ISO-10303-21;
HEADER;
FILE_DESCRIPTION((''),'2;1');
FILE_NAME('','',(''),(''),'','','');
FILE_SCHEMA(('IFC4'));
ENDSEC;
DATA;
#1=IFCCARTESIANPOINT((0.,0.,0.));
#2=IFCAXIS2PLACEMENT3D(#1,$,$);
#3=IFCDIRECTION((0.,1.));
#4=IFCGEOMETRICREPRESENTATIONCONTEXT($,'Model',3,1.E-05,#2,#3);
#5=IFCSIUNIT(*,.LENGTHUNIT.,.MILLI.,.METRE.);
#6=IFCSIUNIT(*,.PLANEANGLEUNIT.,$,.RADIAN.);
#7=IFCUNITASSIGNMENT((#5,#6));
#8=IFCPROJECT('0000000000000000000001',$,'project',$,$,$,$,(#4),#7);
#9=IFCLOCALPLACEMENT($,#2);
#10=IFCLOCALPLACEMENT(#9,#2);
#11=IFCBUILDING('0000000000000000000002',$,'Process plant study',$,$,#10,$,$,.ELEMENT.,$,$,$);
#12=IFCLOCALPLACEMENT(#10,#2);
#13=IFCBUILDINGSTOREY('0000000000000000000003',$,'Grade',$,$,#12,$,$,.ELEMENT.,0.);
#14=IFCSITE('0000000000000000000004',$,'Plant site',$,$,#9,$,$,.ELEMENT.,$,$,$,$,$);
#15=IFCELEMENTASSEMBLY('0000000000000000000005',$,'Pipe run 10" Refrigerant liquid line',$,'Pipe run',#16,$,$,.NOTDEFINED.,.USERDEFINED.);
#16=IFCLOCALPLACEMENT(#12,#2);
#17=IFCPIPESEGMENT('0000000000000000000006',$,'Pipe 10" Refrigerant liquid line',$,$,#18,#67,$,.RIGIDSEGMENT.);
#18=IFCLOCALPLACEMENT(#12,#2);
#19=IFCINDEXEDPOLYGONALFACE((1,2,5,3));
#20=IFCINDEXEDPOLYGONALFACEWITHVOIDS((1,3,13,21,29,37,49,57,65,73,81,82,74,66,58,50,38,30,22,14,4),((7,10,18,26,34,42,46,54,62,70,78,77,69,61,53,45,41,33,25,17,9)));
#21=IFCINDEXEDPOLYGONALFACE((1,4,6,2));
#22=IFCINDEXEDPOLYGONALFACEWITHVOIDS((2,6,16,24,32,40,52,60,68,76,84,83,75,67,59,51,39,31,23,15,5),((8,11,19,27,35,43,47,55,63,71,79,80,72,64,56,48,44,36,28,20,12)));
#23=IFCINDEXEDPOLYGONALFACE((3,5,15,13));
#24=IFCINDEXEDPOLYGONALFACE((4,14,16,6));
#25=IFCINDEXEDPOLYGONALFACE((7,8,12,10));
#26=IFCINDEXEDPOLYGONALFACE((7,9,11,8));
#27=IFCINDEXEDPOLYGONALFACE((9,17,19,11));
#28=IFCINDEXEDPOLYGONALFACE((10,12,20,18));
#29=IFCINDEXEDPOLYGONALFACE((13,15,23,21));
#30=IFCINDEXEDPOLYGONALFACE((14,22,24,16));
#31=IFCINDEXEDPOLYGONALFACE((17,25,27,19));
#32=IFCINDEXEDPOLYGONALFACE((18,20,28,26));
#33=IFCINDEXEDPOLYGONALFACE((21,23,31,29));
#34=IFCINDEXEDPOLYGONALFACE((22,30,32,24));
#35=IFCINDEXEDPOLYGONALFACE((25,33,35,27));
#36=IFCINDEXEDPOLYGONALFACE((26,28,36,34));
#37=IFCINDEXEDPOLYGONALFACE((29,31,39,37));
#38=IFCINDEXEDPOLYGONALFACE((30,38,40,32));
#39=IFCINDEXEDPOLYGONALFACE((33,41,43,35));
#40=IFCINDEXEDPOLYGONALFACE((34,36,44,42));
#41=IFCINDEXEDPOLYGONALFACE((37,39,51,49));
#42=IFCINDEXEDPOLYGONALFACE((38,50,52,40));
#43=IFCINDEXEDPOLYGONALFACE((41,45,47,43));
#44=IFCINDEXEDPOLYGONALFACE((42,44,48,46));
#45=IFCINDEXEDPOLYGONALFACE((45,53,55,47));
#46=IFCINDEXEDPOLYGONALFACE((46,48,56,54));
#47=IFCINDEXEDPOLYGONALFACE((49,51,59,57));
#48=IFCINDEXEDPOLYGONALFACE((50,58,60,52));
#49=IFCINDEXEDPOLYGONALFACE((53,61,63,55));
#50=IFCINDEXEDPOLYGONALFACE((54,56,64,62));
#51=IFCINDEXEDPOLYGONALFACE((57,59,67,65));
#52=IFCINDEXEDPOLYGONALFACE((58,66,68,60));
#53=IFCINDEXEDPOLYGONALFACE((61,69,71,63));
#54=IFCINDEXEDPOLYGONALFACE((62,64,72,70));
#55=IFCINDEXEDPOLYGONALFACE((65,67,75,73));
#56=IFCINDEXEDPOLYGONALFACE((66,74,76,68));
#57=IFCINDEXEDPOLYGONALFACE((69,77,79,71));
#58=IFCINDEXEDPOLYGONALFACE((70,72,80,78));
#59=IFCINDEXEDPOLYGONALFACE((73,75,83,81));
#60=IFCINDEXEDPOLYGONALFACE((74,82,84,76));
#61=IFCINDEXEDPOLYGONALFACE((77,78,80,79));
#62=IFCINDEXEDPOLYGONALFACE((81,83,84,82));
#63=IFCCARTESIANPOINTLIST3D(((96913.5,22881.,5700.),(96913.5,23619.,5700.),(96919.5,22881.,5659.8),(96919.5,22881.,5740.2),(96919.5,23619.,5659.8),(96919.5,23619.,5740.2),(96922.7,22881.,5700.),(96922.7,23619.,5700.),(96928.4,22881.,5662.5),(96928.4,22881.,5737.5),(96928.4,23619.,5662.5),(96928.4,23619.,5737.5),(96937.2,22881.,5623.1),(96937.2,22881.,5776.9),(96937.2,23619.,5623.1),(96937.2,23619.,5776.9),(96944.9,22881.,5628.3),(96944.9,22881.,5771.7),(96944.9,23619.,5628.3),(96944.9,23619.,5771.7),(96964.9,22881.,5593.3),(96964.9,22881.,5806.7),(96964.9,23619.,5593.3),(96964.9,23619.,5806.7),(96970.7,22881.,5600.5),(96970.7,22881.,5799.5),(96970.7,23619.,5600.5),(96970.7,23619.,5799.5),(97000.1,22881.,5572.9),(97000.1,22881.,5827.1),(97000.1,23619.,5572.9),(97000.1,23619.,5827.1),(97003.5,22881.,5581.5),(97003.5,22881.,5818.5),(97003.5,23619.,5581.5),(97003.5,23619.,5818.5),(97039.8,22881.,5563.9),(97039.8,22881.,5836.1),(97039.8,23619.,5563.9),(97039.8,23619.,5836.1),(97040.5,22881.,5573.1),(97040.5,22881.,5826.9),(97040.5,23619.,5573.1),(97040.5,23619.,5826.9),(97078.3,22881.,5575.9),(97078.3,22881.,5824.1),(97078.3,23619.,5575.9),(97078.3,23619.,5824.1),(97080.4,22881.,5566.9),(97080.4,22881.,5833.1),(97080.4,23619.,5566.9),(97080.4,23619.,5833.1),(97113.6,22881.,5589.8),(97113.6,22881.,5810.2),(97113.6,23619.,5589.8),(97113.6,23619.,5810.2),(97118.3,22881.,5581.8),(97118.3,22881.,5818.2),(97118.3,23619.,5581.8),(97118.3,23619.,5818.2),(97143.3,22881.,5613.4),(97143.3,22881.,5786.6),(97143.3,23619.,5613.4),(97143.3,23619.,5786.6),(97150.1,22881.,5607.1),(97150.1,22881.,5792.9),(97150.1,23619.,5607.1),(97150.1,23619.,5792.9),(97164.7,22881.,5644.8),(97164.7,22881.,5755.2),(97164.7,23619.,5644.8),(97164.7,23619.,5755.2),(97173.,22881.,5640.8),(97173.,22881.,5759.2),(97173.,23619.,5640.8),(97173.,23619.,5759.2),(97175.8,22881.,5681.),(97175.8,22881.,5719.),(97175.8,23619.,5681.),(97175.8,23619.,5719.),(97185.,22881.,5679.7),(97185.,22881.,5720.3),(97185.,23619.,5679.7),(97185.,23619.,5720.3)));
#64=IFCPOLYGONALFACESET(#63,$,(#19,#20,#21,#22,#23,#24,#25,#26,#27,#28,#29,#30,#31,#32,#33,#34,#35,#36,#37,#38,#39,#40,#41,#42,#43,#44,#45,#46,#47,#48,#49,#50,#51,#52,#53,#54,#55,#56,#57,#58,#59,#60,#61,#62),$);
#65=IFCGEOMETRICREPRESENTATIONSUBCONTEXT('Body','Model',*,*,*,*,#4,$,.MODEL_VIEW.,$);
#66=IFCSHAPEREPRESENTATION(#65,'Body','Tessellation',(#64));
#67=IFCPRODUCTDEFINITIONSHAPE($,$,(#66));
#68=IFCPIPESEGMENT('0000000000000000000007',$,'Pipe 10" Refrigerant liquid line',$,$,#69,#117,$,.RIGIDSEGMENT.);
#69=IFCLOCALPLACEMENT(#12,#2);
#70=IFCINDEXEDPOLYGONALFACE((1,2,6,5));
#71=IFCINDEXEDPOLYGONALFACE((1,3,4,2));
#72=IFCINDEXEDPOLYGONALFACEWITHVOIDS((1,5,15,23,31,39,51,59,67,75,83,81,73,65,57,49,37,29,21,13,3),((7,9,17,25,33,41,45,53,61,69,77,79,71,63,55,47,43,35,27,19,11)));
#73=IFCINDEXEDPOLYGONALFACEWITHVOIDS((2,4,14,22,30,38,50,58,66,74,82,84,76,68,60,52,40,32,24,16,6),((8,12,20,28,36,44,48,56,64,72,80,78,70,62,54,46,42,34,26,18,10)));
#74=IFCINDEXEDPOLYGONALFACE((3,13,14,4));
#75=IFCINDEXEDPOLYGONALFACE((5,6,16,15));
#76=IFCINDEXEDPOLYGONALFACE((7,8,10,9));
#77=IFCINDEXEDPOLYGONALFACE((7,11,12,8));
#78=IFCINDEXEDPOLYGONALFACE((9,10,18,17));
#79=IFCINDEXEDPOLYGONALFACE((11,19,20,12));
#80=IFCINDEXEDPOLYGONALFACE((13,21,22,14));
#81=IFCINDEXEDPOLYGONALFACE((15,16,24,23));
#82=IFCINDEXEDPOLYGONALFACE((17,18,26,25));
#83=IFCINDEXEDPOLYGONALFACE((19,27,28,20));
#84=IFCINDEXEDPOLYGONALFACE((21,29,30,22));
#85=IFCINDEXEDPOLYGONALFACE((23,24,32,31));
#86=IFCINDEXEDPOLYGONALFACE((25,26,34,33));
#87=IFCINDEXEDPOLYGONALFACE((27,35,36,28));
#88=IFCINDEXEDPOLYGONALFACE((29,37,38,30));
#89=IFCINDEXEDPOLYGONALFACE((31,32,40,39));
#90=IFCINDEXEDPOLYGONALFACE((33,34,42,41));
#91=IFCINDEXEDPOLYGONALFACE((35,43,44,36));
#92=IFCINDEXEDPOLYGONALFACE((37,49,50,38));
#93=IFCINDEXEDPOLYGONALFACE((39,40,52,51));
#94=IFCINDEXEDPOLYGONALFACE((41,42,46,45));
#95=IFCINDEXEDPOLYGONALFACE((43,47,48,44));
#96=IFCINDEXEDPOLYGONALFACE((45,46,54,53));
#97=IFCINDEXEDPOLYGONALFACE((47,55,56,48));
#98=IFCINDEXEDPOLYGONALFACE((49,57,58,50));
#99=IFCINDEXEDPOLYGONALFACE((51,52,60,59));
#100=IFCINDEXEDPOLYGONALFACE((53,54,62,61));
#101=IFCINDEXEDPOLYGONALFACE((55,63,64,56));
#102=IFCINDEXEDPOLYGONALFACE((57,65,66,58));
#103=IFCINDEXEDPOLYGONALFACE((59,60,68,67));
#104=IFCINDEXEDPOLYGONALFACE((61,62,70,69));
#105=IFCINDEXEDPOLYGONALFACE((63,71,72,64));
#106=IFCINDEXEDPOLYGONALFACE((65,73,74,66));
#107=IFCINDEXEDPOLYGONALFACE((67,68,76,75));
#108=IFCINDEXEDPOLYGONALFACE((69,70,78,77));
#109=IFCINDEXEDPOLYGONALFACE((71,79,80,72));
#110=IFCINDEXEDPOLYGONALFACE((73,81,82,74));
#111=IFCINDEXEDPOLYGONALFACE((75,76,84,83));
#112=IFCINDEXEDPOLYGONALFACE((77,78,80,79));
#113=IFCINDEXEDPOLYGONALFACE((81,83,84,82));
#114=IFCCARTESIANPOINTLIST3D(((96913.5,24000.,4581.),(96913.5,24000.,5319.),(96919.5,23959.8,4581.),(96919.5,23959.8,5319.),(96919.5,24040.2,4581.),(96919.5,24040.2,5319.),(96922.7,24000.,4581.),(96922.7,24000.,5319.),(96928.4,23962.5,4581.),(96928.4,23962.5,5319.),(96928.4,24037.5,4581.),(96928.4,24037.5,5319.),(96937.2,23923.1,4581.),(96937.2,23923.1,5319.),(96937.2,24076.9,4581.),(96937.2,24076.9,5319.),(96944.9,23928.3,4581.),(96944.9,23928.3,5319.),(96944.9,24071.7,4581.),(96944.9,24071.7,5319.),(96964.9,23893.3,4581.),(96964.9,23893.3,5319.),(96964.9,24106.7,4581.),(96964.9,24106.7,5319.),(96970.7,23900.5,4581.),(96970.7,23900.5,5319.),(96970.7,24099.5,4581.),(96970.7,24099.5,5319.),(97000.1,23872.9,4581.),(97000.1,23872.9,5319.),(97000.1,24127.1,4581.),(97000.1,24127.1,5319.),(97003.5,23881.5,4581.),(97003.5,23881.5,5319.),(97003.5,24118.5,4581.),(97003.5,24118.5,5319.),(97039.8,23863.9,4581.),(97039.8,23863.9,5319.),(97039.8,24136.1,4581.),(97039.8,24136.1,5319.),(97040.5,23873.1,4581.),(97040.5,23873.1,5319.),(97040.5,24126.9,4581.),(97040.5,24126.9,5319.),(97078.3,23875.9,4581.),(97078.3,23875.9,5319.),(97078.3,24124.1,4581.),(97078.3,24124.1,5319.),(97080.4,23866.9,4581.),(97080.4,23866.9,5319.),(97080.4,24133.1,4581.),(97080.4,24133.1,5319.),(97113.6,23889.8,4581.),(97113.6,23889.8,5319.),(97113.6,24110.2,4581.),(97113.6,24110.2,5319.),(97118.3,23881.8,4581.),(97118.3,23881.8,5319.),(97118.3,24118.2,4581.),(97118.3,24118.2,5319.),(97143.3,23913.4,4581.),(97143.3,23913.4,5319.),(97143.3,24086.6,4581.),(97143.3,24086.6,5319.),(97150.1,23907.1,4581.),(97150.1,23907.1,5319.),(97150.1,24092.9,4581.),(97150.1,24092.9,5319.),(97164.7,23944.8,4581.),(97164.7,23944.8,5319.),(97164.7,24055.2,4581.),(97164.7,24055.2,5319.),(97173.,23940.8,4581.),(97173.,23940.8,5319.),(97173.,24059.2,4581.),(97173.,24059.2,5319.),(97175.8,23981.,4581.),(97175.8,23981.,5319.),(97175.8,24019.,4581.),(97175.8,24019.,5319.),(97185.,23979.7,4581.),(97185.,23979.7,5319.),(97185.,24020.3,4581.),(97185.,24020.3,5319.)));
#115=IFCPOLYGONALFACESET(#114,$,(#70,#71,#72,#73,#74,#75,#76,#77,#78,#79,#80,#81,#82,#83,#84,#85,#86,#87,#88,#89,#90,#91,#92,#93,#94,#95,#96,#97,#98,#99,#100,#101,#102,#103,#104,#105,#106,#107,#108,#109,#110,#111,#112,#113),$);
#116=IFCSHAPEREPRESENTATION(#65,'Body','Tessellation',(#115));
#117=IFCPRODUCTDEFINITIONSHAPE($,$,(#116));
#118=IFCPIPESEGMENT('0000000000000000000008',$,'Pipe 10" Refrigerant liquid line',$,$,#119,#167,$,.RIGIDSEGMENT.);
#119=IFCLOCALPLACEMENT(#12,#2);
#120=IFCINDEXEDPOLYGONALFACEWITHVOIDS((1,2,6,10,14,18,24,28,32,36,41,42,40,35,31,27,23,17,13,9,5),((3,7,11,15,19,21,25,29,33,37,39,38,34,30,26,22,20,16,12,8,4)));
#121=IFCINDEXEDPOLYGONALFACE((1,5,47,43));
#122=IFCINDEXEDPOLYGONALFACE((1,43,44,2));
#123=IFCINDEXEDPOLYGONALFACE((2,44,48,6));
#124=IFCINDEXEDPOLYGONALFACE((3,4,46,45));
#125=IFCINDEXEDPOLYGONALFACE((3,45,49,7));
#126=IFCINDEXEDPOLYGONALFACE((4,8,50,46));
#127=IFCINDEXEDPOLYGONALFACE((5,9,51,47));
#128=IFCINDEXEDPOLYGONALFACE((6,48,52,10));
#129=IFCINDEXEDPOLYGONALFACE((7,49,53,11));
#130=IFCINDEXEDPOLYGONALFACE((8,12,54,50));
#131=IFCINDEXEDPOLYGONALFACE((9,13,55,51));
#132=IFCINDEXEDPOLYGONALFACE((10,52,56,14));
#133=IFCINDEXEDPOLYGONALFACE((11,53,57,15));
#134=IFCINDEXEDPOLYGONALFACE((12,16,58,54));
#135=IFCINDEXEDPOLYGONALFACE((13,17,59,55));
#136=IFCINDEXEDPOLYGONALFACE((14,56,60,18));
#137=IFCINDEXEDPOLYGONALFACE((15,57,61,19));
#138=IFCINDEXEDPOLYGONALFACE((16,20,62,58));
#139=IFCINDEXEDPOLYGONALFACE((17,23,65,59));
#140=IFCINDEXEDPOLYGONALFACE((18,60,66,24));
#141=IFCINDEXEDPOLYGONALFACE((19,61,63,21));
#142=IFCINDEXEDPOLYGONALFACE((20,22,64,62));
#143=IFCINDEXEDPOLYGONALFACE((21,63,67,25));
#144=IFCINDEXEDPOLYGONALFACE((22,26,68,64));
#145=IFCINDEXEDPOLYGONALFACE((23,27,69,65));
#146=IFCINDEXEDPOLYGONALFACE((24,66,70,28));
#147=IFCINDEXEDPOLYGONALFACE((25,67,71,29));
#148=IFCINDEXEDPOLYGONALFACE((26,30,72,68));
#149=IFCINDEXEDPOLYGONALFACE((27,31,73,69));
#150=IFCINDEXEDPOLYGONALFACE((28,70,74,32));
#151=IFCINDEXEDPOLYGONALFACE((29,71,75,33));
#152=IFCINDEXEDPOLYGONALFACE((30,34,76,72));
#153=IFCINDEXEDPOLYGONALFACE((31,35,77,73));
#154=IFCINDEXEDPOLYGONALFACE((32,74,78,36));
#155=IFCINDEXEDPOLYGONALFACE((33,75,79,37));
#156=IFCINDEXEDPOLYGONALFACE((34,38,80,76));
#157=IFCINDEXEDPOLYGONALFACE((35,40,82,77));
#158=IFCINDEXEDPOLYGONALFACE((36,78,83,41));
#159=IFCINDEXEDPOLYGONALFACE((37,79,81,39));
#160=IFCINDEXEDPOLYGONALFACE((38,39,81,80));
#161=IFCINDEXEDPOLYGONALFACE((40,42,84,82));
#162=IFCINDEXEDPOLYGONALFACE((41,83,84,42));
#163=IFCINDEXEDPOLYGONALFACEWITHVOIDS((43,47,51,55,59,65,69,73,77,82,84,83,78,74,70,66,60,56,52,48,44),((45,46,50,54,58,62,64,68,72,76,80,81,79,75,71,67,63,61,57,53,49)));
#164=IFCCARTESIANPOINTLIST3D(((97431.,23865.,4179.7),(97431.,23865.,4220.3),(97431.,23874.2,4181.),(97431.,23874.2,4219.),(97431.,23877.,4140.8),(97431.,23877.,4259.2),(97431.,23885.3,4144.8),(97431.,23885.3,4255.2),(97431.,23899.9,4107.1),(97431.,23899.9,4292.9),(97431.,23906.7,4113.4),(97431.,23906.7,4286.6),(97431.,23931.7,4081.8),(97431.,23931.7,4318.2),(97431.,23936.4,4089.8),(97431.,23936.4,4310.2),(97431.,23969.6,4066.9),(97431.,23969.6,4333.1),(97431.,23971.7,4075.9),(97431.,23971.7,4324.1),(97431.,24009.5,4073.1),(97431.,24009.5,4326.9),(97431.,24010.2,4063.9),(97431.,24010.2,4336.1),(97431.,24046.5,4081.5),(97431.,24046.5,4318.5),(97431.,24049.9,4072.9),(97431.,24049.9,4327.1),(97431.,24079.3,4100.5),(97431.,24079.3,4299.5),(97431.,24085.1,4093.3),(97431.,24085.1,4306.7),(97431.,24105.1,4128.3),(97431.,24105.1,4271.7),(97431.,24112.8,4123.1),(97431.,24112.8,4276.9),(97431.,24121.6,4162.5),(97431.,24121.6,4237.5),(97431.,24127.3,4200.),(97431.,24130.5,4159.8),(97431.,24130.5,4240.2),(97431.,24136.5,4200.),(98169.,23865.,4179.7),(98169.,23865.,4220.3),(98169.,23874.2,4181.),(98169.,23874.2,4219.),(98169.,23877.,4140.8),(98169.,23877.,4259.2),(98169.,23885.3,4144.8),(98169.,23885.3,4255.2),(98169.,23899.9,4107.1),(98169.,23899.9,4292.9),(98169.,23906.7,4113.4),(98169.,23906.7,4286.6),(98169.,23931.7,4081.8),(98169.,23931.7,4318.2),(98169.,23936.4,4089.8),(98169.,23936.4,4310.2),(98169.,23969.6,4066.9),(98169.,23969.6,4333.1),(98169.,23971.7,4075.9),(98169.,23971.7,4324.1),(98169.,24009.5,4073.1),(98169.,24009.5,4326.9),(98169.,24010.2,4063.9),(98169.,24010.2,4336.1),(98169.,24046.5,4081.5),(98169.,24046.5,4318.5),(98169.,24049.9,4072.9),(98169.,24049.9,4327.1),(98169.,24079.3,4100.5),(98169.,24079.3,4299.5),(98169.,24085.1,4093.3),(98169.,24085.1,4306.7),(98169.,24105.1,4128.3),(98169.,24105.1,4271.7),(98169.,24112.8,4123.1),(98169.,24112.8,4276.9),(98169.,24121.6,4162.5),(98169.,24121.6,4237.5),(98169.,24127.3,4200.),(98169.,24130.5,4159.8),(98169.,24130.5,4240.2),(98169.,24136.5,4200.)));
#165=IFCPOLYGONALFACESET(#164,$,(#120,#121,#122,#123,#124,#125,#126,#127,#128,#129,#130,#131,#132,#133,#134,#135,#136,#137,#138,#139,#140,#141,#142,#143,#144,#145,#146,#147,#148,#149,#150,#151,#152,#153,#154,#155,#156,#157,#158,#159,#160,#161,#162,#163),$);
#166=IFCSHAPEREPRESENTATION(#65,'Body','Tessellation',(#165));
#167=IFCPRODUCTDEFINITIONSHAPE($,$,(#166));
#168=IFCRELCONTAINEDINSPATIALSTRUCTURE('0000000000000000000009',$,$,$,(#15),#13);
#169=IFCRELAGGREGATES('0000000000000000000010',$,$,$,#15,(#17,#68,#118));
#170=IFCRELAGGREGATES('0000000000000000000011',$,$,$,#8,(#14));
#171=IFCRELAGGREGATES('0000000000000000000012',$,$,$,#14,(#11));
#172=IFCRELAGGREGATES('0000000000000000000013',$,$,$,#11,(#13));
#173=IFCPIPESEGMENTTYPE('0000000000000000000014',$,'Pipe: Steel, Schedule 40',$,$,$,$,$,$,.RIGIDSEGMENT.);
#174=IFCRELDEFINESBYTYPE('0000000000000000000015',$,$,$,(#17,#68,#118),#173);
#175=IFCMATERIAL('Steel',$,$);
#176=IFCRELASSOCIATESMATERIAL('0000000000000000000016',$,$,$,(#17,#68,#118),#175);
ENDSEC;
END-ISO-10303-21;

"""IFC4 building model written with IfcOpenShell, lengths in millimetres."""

from ifc_helpers import new_model, si_unit, direction, frame, origin, origin_with_axes, origin_2d, place, context, subcontext, project, spatial, hollow_circle, extrude, material, type_object, element, aggregate, save


model = new_model("IFC4")

# Units and contexts
model_context = context("Model", 3, precision=1e-05, world=origin(), true_north=direction((0.0, 1.0)))
body_context = subcontext(model_context, "Body", "Model", "MODEL_VIEW")
ifc_project = project(units=[si_unit("LENGTHUNIT", "METRE", prefix="MILLI"), si_unit("PLANEANGLEUNIT", "RADIAN")], contexts=[model_context])

# Site, building, storey
site_placement = place(None, origin())
site = spatial("IfcSite", under=ifc_project, at=site_placement, Name="Plant site", CompositionType="ELEMENT")
building_placement = place(site_placement, origin())
building = spatial("IfcBuilding", under=site, at=building_placement, Name="Process plant study", CompositionType="ELEMENT")
storey_placement = place(building_placement, origin())
storey = spatial("IfcBuildingStorey", under=building, at=storey_placement, Name="Grade", CompositionType="ELEMENT", Elevation=0.0)

# Element assembly, pipe segments
assembly_1_placement = place(storey_placement, origin_with_axes())
assembly_1 = element("IfcElementAssembly", 1, at=assembly_1_placement, inside=storey, Name="Pipe run 10\" Refrigerant liquid line", ObjectType="Pipe run", AssemblyPlace="NOTDEFINED", PredefinedType="USERDEFINED")
ifc_material = material(Name="Steel")
pipe_segment_type = type_object("IfcPipeSegmentType", Name="Pipe: Steel, Schedule 40", PredefinedType="RIGIDSEGMENT")
pipe_segment_1_placement = place(storey_placement, origin_with_axes())
pipe_segment_1 = element("IfcPipeSegment", 2, at=pipe_segment_1_placement, type_object=pipe_segment_type, material=ifc_material, Name="Pipe 10\" Refrigerant liquid line", PredefinedType="RIGIDSEGMENT", context=body_context, shape_type="SweptSolid", body=[
    extrude(hollow_circle(Radius=136.5, WallThickness=9.3, at=origin_2d()), frame((97050.0, 22881.0, 5700.0), z_axis=(0.0, 1.0, 0.0), x_axis=(-1.0, 0.0, 0.0)), (0.0, 0.0, 1.0), 738.0),
])
pipe_segment_2_placement = place(storey_placement, origin_with_axes())
pipe_segment_2 = element("IfcPipeSegment", 3, at=pipe_segment_2_placement, type_object=pipe_segment_type, material=ifc_material, Name="Pipe 10\" Refrigerant liquid line", PredefinedType="RIGIDSEGMENT", context=body_context, shape_type="SweptSolid", body=[
    extrude(hollow_circle(Radius=136.5, WallThickness=9.3, at=origin_2d()), frame((97050.0, 24000.0, 5319.0), z_axis=(0.0, 0.0, -1.0), x_axis=(-1.0, 0.0, 0.0)), (0.0, 0.0, 1.0), 738.0),
])
pipe_segment_3_placement = place(storey_placement, origin_with_axes())
pipe_segment_3 = element("IfcPipeSegment", 4, at=pipe_segment_3_placement, type_object=pipe_segment_type, material=ifc_material, Name="Pipe 10\" Refrigerant liquid line", PredefinedType="RIGIDSEGMENT", context=body_context, shape_type="SweptSolid", body=[
    extrude(hollow_circle(Radius=136.5, WallThickness=9.3, at=origin_2d()), frame((97431.0, 24000.0, 4200.0), z_axis=(1.0, 0.0, 0.0), x_axis=(0.0, 1.0, 0.0)), (0.0, 0.0, 1.0), 738.0),
])

aggregate(assembly_1, [pipe_segment_1, pipe_segment_2, pipe_segment_3])

save(model, "model.ifc")
